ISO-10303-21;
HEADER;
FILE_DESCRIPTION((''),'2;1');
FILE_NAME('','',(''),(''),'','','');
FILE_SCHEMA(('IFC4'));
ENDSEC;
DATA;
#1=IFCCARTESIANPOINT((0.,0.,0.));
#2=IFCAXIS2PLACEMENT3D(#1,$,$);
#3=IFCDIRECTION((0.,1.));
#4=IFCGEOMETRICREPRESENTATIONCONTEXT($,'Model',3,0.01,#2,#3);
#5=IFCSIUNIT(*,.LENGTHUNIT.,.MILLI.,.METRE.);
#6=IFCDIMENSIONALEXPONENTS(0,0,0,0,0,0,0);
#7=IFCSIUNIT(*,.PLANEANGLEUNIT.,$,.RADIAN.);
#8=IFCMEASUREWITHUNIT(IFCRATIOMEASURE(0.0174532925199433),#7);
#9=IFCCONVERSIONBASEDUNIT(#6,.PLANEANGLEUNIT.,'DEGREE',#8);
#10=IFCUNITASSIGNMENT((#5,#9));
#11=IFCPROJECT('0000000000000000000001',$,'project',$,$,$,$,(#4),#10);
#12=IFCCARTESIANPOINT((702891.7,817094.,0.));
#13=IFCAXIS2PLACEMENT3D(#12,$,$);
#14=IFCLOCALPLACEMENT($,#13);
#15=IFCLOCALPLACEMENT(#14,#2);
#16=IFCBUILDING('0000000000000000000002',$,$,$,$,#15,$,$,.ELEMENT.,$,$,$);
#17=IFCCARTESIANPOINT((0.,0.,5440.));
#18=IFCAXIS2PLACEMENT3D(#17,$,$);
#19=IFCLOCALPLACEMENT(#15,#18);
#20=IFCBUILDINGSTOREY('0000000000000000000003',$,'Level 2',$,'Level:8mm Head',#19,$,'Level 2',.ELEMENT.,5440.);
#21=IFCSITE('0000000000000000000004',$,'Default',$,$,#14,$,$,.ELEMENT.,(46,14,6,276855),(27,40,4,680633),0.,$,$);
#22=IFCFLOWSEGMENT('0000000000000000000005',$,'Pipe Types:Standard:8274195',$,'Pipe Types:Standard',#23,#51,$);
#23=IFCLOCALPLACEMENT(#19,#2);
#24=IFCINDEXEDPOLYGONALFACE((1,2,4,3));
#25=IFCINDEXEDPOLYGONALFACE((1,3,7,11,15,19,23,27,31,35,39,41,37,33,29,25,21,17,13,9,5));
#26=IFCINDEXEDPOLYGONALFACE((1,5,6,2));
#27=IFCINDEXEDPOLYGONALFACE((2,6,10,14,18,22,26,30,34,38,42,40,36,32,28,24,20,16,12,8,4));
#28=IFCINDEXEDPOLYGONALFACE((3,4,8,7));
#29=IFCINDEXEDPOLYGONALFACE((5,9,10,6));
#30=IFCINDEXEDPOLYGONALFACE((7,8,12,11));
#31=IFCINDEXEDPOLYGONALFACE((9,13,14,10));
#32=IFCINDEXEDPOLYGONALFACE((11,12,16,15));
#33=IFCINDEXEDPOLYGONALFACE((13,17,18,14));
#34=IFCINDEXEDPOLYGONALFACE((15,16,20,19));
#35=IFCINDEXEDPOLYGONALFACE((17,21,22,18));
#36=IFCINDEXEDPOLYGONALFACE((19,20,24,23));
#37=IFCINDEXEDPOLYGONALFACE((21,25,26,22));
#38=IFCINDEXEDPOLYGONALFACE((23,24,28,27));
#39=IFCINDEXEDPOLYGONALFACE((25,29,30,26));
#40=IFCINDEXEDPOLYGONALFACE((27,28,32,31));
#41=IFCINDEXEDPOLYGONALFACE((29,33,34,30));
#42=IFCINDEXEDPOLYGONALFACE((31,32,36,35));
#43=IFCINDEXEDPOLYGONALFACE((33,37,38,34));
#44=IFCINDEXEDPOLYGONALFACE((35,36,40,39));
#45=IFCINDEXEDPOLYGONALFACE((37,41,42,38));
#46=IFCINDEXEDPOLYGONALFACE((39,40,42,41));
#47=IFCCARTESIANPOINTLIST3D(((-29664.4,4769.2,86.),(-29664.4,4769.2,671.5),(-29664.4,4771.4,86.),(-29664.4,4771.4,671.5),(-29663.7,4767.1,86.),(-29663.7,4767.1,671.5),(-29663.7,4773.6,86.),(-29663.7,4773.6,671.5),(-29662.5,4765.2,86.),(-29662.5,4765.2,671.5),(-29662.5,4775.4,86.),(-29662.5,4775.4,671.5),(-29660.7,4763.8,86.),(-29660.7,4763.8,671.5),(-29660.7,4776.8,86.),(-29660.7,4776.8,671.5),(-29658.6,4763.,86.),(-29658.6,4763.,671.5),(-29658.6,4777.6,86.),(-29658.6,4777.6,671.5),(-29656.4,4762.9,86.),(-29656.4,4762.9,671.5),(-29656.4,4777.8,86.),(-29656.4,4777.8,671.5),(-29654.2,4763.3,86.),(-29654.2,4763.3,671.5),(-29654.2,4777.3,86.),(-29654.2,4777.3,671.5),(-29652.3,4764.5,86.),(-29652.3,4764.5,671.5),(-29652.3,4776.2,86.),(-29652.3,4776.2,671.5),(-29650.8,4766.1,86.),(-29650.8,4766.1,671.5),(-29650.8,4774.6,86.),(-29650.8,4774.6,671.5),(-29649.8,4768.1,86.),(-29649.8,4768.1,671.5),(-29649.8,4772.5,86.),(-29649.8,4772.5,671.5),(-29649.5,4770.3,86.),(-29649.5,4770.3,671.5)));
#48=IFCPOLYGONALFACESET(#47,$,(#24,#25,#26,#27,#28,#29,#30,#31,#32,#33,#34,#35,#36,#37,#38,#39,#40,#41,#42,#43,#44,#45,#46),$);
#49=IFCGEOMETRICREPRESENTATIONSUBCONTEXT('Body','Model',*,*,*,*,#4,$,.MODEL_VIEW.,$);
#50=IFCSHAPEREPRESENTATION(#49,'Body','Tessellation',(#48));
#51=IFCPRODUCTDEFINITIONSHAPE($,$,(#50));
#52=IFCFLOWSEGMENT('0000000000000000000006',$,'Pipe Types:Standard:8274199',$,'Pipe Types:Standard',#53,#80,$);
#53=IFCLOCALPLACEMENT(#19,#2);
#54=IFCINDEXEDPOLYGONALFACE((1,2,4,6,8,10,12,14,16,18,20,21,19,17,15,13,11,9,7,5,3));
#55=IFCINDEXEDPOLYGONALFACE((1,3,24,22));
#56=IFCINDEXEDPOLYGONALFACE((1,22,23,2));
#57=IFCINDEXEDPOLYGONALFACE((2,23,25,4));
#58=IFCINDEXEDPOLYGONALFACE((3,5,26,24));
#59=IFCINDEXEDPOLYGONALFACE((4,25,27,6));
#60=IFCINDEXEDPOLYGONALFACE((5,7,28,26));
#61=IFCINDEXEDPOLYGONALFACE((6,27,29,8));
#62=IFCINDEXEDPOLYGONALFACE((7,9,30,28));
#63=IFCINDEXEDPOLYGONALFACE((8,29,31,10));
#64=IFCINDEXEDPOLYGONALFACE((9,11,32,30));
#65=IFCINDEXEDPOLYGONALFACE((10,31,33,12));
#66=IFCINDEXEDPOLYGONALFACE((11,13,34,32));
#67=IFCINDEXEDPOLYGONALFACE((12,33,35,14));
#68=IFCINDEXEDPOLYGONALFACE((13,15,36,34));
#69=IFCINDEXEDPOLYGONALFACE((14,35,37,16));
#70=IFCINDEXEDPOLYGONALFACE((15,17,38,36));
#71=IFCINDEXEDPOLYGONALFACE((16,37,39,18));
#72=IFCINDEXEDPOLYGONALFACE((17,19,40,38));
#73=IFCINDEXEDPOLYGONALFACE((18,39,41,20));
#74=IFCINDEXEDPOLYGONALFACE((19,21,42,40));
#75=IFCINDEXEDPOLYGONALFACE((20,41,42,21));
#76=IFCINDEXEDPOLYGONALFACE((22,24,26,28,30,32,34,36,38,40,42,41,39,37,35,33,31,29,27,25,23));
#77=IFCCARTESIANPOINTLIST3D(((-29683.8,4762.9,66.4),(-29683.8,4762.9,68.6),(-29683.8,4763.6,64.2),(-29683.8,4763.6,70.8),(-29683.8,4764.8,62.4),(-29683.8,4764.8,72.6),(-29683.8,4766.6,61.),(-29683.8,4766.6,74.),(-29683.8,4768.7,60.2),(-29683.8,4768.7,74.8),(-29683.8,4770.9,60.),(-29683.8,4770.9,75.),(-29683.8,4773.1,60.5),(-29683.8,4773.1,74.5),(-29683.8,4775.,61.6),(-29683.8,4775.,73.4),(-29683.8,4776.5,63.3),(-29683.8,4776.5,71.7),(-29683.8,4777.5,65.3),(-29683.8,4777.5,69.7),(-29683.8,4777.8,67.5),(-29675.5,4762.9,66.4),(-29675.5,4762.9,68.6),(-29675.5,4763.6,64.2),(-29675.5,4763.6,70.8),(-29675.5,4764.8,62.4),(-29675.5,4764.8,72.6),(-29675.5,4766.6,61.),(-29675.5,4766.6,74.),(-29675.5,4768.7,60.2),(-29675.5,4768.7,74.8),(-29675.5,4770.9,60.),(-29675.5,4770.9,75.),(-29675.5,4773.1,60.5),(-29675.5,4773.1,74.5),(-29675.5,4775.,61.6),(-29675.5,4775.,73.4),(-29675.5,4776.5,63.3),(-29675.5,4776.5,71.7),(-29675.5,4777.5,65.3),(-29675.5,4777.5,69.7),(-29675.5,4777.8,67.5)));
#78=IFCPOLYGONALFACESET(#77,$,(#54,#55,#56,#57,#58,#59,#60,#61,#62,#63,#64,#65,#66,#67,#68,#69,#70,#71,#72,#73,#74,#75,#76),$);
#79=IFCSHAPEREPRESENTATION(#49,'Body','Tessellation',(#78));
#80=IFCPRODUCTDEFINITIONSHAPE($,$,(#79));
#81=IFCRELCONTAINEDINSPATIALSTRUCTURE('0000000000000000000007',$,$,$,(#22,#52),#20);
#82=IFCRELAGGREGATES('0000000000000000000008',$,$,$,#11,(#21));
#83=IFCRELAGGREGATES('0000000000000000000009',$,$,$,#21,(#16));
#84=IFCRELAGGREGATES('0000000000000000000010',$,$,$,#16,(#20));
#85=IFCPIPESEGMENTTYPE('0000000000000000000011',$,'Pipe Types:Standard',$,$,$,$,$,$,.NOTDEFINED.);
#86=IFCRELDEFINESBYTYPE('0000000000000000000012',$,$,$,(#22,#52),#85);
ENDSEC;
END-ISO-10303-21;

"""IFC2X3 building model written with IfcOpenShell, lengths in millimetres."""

from ifc_helpers import new_model, entity, si_unit, converted_unit, direction, frame, frame_2d, origin, origin_2d_with_axis, place, context, subcontext, project, spatial, circle, extrude, type_object, element, save


model = new_model("IFC2X3")

# Units and contexts
model_context = context("Model", 3, precision=0.01, world=origin(), true_north=direction((0.0, 1.0)))
body_context = subcontext(model_context, "Body", "Model", "MODEL_VIEW")
ifc_project = project(units=[si_unit("LENGTHUNIT", "METRE", prefix="MILLI"), converted_unit("PLANEANGLEUNIT", "DEGREE", entity("IfcRatioMeasure", 0.0174532925199433), si_unit("PLANEANGLEUNIT", "RADIAN"), dimensions=[0, 0, 0, 0, 0, 0, 0])], contexts=[model_context])

# Site, building, storey
site_placement = place(None, frame((702891.7, 817094.0, 0.0)))
site = spatial("IfcSite", under=ifc_project, at=site_placement, Name="Default", CompositionType="ELEMENT", RefLatitude=(46, 14, 6, 276855), RefLongitude=(27, 40, 4, 680633), RefElevation=0.0)
building_placement = place(site_placement, origin())
building = spatial("IfcBuilding", under=site, at=building_placement, CompositionType="ELEMENT")
storey_placement = place(building_placement, frame((0.0, 0.0, 5440.0)))
storey = spatial("IfcBuildingStorey", under=building, at=storey_placement, Name="Level 2", ObjectType="Level:8mm Head", LongName="Level 2", CompositionType="ELEMENT", Elevation=5440.0)

# Flow segments
pipe_segment_type = type_object("IfcPipeSegmentType", Name="Pipe Types:Standard", PredefinedType="NOTDEFINED")
flow_segment_1_placement = place(storey_placement, origin())
element("IfcFlowSegment", 1, at=flow_segment_1_placement, inside=storey, type_object=pipe_segment_type, Name="Pipe Types:Standard:8274195", ObjectType="Pipe Types:Standard", context=body_context, shape_type="SweptSolid", body=[
    extrude(circle(Radius=7.5, at=origin_2d_with_axis()), frame((-29657.0, 4770.3, 86.0)), (0.0, 0.0, 1.0), 585.5),
])
flow_segment_2_placement = place(storey_placement, origin())
element("IfcFlowSegment", 2, at=flow_segment_2_placement, inside=storey, type_object=pipe_segment_type, Name="Pipe Types:Standard:8274199", ObjectType="Pipe Types:Standard", context=body_context, shape_type="SweptSolid", body=[
    extrude(circle(Radius=7.5, at=frame_2d((0.0, 0.0), x_axis=(1.0, 0.0))), frame((-29683.8, 4770.3, 67.5), z_axis=(1.0, 0.0, 0.0), x_axis=(0.0, 1.0, 0.0)), (0.0, 0.0, 1.0), 8.3),
])

save(model, "model.ifc")
